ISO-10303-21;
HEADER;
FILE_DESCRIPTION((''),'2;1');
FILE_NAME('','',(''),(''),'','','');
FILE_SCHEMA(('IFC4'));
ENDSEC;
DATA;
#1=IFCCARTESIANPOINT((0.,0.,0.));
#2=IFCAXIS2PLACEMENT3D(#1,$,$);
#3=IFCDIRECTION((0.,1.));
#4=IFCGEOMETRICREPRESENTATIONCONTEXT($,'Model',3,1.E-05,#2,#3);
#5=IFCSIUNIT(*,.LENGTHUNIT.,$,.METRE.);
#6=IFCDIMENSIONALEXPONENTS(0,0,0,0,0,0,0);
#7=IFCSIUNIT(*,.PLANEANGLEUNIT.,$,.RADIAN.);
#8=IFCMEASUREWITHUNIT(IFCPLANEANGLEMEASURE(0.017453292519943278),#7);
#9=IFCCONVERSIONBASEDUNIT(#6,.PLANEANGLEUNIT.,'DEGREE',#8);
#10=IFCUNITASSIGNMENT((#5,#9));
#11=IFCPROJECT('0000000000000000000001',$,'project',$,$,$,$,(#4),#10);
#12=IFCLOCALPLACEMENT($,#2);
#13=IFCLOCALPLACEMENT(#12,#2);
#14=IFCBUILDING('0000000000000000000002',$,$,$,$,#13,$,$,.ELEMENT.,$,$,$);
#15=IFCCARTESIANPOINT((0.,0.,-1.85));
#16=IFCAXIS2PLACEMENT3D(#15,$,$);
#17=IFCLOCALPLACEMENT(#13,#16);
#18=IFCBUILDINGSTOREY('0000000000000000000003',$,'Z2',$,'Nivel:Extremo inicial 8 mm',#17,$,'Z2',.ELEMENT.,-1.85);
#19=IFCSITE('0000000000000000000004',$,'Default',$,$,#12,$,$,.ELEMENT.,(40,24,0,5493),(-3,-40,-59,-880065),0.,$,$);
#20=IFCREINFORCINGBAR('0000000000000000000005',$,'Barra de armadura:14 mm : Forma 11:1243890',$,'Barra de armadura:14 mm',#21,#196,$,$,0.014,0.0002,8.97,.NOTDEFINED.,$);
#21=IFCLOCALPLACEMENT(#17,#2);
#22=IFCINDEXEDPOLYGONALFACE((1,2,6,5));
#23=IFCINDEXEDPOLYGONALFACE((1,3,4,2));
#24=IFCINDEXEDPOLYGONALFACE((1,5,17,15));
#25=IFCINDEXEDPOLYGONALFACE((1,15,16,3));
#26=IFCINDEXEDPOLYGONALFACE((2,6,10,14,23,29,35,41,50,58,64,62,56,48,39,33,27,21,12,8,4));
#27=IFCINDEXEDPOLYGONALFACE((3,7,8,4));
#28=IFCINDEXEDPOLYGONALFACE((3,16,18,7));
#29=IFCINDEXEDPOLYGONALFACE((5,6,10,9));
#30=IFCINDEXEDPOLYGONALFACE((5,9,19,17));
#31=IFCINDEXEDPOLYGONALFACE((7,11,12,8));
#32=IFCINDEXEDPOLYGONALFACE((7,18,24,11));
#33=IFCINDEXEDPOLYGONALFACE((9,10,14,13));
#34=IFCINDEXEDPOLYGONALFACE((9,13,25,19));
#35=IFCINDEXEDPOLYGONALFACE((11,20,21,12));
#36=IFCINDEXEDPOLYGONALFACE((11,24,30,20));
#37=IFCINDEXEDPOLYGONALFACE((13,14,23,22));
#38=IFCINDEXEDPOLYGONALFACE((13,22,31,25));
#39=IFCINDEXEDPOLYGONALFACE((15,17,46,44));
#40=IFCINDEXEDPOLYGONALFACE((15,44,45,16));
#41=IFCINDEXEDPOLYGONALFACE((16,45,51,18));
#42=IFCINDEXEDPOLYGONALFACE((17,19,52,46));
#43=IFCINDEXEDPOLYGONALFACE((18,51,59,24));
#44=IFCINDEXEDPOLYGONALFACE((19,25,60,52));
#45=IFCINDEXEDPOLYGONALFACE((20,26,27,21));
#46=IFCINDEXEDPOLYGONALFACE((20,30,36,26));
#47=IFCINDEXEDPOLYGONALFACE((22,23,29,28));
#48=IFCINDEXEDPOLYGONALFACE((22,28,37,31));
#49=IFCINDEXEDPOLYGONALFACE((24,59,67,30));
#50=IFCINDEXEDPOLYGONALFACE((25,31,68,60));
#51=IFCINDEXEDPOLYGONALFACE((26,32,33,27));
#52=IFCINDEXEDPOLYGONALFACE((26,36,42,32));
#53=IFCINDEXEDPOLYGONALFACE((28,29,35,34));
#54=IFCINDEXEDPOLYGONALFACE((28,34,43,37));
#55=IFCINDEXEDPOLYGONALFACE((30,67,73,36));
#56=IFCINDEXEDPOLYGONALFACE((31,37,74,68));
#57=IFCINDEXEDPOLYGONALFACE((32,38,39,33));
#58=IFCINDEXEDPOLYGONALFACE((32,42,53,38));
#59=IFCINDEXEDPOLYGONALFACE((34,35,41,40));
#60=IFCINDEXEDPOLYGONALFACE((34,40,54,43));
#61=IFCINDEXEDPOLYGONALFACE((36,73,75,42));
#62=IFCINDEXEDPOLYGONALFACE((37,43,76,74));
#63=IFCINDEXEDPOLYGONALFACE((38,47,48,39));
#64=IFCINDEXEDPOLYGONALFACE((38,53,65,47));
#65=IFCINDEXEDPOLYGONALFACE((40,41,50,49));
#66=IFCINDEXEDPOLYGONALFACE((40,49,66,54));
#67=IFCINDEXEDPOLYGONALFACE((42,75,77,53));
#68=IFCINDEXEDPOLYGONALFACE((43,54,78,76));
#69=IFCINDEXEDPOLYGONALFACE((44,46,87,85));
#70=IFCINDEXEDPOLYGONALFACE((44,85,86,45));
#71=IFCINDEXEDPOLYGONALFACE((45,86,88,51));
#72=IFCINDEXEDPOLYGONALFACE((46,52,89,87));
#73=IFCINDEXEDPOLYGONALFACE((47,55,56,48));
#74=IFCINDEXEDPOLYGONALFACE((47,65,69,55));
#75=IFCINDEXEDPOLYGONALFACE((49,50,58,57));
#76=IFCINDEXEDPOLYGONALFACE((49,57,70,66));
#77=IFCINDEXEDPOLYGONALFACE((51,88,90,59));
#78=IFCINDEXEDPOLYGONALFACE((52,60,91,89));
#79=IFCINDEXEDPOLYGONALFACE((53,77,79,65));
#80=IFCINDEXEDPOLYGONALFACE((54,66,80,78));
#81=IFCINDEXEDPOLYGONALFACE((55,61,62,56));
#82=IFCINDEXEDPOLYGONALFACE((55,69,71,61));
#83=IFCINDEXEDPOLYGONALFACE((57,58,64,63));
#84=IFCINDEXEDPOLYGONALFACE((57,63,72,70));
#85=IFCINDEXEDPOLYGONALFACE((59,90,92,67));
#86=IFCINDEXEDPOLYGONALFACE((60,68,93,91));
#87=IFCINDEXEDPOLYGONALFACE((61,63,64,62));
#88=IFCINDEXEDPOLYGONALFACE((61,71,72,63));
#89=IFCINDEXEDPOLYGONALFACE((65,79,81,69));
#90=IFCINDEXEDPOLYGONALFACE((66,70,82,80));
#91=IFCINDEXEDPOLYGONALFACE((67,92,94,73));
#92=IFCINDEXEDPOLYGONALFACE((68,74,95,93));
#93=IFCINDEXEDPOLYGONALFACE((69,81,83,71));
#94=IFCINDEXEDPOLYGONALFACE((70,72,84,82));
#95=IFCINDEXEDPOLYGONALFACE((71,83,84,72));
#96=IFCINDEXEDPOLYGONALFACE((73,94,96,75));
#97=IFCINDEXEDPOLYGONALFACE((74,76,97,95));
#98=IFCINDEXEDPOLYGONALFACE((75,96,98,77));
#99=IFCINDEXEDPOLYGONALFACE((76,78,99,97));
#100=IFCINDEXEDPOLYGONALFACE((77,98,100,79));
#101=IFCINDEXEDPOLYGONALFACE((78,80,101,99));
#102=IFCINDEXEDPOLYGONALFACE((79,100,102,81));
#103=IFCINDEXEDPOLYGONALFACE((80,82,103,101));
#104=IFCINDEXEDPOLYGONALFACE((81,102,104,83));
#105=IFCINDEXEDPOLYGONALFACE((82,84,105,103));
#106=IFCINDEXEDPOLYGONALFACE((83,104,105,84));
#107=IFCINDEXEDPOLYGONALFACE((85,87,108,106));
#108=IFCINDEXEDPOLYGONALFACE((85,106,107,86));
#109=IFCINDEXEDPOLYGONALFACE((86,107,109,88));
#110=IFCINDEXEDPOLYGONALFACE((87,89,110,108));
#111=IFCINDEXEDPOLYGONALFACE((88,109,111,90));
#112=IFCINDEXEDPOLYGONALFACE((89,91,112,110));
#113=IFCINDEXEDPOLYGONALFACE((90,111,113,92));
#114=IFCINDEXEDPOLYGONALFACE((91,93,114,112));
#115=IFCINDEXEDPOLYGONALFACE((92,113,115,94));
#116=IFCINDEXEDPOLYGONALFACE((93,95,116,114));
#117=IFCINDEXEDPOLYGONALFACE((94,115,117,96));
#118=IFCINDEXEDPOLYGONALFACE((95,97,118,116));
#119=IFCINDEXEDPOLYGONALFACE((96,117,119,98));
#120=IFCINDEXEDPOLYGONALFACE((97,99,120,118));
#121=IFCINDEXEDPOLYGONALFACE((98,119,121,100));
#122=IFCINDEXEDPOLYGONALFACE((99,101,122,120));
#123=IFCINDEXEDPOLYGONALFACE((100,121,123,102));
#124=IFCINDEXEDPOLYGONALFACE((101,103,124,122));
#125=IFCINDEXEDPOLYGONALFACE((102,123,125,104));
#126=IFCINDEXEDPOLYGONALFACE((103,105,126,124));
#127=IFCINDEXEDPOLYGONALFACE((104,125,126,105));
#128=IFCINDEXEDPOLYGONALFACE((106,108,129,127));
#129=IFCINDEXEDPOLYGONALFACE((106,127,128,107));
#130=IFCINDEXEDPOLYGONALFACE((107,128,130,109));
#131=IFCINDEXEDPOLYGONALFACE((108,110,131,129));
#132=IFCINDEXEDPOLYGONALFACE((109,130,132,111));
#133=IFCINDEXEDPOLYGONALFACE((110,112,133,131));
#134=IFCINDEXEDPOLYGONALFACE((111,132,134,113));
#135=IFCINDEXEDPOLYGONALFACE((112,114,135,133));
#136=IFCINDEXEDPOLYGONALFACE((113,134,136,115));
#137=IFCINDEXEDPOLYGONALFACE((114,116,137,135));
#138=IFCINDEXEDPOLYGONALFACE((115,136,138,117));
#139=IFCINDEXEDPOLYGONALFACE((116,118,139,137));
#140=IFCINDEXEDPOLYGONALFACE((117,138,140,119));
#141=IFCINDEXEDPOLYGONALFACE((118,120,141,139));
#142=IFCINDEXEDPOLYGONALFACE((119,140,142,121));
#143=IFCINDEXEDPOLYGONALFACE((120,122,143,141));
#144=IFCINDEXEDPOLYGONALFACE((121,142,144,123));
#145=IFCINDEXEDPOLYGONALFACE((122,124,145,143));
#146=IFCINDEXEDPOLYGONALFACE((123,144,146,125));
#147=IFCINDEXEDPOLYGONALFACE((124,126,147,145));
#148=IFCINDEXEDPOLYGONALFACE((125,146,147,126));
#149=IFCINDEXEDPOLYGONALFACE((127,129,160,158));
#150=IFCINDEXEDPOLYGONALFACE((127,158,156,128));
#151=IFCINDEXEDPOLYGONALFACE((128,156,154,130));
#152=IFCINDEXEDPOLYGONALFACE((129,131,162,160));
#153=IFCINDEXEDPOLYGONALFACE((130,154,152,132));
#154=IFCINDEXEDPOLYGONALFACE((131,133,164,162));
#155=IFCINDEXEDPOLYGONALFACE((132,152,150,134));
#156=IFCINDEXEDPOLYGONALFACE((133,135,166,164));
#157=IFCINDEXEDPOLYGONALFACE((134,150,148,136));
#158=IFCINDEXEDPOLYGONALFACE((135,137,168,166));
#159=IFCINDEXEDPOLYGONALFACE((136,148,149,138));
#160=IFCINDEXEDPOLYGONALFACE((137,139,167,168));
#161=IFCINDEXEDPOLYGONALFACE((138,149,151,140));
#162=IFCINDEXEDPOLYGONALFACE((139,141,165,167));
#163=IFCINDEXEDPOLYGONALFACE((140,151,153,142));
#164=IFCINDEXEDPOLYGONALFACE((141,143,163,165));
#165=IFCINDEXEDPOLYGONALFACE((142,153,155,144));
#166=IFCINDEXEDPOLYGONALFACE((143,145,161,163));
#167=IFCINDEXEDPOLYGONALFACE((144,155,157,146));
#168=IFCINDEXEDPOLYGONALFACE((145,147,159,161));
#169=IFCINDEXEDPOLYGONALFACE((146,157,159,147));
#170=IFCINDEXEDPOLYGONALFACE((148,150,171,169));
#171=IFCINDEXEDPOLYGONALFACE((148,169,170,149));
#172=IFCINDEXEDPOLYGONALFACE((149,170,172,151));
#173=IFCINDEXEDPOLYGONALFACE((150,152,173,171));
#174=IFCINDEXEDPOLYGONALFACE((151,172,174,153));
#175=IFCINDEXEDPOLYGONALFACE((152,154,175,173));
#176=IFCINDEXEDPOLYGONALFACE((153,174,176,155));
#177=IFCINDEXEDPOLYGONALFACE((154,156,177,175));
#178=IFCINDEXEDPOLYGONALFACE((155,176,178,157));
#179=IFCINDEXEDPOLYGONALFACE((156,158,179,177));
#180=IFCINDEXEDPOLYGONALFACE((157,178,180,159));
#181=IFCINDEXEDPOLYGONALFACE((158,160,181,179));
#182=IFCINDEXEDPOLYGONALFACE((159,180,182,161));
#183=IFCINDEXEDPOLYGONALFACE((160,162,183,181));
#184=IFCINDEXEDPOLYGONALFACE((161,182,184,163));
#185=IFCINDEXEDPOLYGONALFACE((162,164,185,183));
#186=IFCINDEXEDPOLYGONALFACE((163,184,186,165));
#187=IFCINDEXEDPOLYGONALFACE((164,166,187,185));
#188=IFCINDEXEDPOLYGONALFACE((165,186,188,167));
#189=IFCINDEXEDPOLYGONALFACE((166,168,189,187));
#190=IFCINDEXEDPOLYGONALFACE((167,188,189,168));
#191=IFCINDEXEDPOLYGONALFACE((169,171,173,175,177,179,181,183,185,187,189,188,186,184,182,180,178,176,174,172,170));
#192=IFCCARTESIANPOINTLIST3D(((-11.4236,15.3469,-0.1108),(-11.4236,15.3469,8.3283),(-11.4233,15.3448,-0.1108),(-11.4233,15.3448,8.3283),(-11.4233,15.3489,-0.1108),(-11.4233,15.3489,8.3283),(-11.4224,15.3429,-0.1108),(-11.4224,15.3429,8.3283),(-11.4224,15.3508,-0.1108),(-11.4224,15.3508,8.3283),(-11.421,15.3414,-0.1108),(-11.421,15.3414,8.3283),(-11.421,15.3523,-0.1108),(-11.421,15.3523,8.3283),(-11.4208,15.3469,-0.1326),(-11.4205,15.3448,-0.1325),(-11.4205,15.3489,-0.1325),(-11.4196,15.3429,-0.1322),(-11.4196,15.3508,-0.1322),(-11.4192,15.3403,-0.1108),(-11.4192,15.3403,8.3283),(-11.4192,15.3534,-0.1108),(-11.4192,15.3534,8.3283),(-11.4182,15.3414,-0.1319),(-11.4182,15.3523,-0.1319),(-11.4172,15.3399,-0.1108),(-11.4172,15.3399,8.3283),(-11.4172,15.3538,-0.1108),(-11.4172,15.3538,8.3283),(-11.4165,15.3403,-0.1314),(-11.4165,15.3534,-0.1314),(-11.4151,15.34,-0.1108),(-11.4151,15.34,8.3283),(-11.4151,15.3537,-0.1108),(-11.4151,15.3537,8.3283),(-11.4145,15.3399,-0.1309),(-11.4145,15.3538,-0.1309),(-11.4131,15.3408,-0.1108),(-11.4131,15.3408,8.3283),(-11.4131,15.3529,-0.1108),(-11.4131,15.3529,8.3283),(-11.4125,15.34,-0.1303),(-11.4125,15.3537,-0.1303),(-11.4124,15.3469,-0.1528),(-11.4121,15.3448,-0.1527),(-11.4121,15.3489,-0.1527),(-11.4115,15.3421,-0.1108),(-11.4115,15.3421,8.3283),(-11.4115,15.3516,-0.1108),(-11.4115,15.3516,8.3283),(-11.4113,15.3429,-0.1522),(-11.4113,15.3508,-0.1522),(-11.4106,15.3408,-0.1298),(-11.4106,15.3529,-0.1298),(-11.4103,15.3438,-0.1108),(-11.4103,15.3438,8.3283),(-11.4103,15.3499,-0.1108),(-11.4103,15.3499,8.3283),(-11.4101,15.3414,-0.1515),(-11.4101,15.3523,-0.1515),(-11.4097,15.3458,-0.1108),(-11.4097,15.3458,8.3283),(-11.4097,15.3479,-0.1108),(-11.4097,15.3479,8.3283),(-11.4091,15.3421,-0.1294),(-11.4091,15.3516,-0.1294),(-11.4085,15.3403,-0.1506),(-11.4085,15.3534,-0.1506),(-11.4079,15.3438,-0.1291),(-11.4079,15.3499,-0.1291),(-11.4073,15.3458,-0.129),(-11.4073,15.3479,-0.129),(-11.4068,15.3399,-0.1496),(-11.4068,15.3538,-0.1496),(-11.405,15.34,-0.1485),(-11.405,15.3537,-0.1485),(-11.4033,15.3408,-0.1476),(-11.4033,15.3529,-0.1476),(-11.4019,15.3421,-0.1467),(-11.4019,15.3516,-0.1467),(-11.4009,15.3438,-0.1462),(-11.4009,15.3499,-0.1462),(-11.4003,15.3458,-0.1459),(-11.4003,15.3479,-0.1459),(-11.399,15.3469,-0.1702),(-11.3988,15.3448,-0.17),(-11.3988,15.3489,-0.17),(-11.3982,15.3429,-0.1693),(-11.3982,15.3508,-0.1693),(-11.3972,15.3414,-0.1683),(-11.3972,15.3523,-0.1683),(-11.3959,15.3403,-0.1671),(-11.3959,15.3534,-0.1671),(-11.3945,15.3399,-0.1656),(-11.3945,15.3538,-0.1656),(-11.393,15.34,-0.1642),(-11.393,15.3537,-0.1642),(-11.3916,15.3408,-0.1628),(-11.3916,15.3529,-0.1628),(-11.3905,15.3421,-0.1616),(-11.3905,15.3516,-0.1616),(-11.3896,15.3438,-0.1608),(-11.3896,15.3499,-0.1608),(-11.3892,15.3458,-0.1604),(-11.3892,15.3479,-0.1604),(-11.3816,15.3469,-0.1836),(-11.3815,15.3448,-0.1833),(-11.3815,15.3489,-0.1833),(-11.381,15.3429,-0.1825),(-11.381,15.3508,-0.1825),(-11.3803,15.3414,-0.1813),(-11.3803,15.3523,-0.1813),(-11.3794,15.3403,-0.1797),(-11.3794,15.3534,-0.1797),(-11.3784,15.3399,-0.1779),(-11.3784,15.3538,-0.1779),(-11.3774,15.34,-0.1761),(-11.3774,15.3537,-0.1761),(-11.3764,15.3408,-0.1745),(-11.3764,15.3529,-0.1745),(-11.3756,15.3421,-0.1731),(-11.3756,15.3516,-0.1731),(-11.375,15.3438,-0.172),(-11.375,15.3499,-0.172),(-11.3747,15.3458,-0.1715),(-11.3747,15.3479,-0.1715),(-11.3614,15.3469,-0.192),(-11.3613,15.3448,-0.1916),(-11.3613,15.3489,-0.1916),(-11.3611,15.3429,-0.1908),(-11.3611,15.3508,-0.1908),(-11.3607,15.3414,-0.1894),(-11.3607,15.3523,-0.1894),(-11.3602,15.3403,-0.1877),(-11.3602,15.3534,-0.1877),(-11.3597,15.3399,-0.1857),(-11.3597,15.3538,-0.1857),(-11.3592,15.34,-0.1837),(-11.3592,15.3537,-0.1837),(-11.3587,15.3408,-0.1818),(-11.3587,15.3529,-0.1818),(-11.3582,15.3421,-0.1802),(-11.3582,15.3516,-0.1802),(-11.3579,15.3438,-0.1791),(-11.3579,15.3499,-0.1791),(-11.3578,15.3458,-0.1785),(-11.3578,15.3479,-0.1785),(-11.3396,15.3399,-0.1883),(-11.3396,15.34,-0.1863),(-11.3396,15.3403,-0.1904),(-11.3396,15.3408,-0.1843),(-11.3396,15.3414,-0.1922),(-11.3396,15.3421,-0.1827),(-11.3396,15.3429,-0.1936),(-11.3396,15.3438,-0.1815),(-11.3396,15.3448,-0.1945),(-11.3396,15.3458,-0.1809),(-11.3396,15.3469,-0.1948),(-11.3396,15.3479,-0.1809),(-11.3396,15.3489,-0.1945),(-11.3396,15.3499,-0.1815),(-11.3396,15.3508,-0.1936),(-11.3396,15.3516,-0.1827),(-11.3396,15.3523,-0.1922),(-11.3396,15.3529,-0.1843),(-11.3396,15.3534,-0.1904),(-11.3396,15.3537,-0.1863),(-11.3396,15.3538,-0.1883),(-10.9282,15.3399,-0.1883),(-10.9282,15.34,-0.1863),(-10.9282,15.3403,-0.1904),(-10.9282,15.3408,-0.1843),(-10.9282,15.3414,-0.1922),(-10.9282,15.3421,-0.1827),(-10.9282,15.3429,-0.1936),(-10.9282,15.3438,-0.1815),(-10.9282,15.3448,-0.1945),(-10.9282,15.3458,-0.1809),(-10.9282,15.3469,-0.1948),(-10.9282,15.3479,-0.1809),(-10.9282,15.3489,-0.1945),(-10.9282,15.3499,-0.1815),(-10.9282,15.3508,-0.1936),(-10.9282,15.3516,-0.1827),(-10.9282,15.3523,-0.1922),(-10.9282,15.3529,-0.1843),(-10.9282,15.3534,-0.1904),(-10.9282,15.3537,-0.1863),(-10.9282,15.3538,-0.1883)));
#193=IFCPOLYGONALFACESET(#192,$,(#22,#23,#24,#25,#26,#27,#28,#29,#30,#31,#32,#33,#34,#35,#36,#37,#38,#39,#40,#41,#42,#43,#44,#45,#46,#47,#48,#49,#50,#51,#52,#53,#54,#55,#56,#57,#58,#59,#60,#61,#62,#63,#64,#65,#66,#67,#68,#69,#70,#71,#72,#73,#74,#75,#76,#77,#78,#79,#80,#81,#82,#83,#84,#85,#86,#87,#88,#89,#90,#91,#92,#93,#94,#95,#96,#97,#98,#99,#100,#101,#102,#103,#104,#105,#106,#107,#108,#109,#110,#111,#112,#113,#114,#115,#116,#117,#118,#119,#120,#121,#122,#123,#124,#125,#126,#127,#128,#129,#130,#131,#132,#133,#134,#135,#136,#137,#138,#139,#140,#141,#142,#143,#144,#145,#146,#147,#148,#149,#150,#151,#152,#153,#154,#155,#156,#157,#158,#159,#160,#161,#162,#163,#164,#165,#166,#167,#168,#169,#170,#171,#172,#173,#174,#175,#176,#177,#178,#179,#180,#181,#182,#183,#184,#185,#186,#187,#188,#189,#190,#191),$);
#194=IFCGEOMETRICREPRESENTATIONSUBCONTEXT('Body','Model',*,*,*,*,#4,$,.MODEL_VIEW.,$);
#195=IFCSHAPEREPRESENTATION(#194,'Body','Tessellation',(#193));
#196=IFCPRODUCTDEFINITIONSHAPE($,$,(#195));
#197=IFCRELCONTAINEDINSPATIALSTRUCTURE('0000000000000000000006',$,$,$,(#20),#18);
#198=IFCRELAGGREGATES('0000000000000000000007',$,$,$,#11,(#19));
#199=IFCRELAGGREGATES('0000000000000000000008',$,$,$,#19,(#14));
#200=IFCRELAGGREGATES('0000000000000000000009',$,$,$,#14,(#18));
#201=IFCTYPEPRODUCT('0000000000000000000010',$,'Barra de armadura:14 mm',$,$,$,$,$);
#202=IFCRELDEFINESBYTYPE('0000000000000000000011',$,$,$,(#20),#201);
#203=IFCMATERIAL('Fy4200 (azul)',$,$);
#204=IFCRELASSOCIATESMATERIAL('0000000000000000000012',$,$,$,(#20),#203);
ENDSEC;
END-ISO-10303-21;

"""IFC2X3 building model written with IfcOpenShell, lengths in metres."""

from ifc_helpers import new_model, entity, si_unit, converted_unit, direction, frame, origin, place, context, subcontext, project, spatial, material, type_object, element, save


model = new_model("IFC2X3")

# Units and contexts
model_context = context("Model", 3, precision=1e-05, world=origin(), true_north=direction((0.0, 1.0)))
body_context = subcontext(model_context, "Body", "Model", "MODEL_VIEW")
ifc_project = project(units=[si_unit("LENGTHUNIT", "METRE"), converted_unit("PLANEANGLEUNIT", "DEGREE", entity("IfcPlaneAngleMeasure", 0.017453292519943278), si_unit("PLANEANGLEUNIT", "RADIAN"), dimensions=[0, 0, 0, 0, 0, 0, 0])], contexts=[model_context])

# Site, building, storey
site_placement = place(None, origin())
site = spatial("IfcSite", under=ifc_project, at=site_placement, Name="Default", CompositionType="ELEMENT", RefLatitude=(40, 24, 0, 5493), RefLongitude=(-3, -40, -59, -880065), RefElevation=0.0)
building_placement = place(site_placement, origin())
building = spatial("IfcBuilding", under=site, at=building_placement, CompositionType="ELEMENT")
storey_placement = place(building_placement, frame((0.0, 0.0, -1.85)))
storey = spatial("IfcBuildingStorey", under=building, at=storey_placement, Name="Z2", ObjectType="Nivel:Extremo inicial 8 mm", LongName="Z2", CompositionType="ELEMENT", Elevation=-1.85)

# Reinforcing bar
ifc_material_1 = material(Name="Fy4200 (azul)")
type_product_1 = type_object("IfcTypeProduct", Name="Barra de armadura:14 mm")
reinforcing_bar_1_placement = place(storey_placement, origin())
element("IfcReinforcingBar", 1, at=reinforcing_bar_1_placement, inside=storey, type_object=type_product_1, material=ifc_material_1, Name="Barra de armadura:14 mm : Forma 11:1243890", ObjectType="Barra de armadura:14 mm", BarLength=8.97, BarRole="NOTDEFINED", CrossSectionArea=0.0002, NominalDiameter=0.014, context=body_context, shape_type="AdvancedSweptSolid", body=[
    entity("IfcSweptDiskSolid", entity("IfcCompositeCurve", [entity("IfcCompositeCurveSegment", "CONTINUOUS", True, entity("IfcPolyline", [entity("IfcCartesianPoint", [-11.4166, 15.3469, 8.3283]), entity("IfcCartesianPoint", [-11.4166, 15.3469, -0.1108])])), entity("IfcCompositeCurveSegment", "CONTINUOUS", True, entity("IfcTrimmedCurve", entity("IfcCircle", entity("IfcAxis2Placement3D", entity("IfcCartesianPoint", [-11.3396, 15.3469, -0.1108]), entity("IfcDirection", [0.0, -1.0, 0.0]), entity("IfcDirection", [0.0, 0.0, -1.0])), 0.077), [entity("IfcParameterValue", 270.0)], [entity("IfcParameterValue", 360.0)], True, "PARAMETER")), entity("IfcCompositeCurveSegment", "CONTINUOUS", True, entity("IfcPolyline", [entity("IfcCartesianPoint", [-11.3396, 15.3469, -0.1878]), entity("IfcCartesianPoint", [-10.9282, 15.3469, -0.1878])]))], False), 0.007, None, 0.0, 92.0),
])

save(model, "model.ifc")
